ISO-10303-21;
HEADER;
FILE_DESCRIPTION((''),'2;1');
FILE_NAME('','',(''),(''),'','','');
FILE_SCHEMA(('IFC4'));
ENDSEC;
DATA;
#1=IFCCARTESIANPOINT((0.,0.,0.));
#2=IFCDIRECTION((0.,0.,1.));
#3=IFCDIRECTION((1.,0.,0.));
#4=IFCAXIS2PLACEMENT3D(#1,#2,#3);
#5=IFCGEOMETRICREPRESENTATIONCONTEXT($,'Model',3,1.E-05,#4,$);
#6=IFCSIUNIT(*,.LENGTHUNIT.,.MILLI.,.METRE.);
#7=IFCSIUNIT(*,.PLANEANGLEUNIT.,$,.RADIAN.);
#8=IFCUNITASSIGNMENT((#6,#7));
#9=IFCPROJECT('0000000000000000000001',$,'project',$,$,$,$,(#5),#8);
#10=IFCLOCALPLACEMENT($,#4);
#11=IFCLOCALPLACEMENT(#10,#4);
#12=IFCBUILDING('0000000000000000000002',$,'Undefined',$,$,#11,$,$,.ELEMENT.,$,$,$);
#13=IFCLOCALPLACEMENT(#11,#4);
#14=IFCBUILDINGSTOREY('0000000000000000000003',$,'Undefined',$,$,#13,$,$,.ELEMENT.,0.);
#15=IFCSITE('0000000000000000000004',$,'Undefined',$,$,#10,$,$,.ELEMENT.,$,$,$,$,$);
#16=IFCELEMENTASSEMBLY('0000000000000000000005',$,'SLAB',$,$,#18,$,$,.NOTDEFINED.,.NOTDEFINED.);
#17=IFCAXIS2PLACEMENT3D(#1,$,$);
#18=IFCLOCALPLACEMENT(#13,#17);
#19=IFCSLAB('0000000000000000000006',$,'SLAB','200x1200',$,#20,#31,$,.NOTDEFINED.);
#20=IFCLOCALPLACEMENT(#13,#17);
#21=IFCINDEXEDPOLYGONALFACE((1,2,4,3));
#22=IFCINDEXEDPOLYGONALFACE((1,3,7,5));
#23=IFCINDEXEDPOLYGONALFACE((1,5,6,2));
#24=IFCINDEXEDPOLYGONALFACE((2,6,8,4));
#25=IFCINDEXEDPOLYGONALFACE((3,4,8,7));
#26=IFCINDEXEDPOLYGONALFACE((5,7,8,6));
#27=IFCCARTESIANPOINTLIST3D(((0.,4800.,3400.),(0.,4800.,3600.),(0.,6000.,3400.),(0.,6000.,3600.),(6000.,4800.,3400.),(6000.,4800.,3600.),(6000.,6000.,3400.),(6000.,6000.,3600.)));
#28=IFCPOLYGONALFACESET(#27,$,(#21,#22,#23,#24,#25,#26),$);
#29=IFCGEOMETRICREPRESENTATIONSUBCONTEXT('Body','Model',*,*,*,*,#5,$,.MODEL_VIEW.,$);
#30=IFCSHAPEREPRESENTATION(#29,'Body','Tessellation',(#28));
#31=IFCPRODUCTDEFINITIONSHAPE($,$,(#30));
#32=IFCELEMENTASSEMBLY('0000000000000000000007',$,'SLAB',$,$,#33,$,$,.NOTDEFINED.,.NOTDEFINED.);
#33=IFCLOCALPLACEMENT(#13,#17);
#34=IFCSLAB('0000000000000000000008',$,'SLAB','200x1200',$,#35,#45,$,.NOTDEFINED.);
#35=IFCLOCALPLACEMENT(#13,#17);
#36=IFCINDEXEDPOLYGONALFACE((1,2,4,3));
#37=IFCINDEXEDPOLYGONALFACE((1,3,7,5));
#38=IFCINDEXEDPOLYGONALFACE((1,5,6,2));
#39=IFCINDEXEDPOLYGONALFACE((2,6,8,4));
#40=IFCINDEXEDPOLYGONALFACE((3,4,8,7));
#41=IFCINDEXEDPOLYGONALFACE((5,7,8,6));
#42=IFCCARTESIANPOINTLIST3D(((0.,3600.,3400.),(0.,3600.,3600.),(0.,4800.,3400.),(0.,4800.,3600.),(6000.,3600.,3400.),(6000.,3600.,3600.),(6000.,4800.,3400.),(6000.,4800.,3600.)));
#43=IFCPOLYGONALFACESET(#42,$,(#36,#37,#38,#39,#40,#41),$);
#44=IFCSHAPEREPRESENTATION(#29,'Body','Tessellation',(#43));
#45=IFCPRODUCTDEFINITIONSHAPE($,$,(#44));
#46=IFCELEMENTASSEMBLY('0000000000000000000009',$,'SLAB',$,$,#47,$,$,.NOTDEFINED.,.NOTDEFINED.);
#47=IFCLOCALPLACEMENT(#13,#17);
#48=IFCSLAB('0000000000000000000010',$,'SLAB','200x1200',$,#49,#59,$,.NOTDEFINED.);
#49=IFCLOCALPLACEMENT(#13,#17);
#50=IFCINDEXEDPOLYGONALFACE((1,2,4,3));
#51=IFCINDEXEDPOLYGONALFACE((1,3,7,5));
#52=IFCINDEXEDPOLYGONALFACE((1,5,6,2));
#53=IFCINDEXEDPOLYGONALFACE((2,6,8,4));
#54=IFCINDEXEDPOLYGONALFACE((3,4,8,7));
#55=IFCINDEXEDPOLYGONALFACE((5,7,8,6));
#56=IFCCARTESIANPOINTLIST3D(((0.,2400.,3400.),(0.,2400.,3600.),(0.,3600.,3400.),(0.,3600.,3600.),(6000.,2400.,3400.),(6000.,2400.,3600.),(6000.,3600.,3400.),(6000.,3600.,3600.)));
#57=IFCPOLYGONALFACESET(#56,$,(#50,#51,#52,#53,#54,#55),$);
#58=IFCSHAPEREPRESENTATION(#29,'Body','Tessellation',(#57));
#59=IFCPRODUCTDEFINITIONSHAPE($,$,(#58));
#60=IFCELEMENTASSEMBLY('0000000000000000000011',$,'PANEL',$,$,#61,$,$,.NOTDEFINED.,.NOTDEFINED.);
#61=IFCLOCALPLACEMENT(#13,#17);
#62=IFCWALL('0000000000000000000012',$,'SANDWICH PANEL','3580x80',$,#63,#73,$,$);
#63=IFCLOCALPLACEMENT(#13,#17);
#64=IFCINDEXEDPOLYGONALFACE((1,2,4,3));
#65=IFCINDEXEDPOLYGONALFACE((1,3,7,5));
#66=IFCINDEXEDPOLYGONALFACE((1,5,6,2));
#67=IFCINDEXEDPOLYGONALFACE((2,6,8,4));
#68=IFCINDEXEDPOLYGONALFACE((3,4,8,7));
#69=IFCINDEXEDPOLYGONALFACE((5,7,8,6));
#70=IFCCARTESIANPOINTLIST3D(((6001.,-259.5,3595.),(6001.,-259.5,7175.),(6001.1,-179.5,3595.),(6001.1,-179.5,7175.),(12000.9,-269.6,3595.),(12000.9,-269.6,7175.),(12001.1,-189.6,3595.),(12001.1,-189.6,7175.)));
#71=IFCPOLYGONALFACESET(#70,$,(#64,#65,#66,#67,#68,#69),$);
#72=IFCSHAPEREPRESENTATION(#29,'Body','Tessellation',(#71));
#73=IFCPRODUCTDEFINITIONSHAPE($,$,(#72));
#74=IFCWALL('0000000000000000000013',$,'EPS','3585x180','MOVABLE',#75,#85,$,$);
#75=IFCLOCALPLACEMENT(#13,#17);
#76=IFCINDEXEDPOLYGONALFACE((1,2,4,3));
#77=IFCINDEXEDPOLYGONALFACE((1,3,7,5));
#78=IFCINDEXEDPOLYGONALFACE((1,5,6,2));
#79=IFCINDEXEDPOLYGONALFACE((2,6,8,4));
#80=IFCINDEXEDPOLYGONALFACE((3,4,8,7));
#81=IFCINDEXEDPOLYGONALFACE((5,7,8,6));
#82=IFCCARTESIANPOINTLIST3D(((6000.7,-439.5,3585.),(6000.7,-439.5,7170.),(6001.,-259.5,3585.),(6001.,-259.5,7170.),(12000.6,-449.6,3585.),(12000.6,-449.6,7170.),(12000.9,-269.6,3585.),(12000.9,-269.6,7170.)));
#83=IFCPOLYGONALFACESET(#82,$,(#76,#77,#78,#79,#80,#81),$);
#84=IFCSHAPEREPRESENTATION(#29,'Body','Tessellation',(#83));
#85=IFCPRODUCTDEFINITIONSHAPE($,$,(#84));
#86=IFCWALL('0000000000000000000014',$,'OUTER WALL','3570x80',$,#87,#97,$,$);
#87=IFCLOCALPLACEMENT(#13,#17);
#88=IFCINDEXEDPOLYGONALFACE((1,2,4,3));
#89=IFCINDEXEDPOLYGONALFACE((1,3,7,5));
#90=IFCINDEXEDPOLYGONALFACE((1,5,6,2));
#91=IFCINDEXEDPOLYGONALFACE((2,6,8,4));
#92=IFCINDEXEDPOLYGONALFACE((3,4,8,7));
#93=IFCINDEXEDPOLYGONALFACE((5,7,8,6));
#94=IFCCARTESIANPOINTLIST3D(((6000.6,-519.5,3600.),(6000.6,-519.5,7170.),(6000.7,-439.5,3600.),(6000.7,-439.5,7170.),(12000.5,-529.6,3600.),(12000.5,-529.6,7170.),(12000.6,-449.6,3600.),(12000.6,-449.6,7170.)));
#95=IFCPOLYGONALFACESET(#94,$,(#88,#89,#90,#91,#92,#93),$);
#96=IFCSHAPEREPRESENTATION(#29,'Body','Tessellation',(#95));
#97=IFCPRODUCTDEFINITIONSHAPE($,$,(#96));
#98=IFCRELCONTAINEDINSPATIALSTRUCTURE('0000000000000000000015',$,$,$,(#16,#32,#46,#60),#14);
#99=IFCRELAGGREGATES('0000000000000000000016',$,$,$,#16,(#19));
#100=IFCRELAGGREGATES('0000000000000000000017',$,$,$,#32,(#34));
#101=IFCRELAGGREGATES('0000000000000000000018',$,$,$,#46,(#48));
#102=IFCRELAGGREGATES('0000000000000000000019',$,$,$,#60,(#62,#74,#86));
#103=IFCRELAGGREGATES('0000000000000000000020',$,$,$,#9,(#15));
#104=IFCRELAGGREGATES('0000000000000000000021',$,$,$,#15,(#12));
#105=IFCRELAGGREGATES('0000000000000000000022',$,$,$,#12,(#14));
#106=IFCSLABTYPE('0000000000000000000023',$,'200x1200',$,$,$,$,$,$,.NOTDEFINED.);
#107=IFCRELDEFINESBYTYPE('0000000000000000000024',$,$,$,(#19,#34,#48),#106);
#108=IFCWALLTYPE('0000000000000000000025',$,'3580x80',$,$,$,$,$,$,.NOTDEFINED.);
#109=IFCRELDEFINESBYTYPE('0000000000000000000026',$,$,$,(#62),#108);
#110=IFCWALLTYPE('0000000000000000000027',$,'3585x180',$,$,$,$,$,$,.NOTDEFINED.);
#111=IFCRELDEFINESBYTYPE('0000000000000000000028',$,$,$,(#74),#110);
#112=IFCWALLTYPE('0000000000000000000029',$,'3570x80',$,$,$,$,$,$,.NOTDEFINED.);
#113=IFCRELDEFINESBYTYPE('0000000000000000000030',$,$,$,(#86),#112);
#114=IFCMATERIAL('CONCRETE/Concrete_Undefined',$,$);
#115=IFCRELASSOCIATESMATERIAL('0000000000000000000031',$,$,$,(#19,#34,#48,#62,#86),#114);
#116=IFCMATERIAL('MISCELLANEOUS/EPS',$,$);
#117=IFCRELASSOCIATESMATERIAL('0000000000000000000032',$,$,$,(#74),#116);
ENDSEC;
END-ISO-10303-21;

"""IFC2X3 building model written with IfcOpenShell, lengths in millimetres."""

from ifc_helpers import new_model, si_unit, frame, frame_2d, origin_with_axes, place, context, subcontext, project, spatial, polyline, rectangle, outline, extrude, material, type_object, element, aggregate, save


model = new_model("IFC2X3")

# Units and contexts
model_context = context("Model", 3, precision=1e-05, world=origin_with_axes())
body_context = subcontext(model_context, "Body", "Model", "MODEL_VIEW")
ifc_project = project(units=[si_unit("LENGTHUNIT", "METRE", prefix="MILLI"), si_unit("PLANEANGLEUNIT", "RADIAN")], contexts=[model_context])

# Site, building, storey
site_placement = place(None, origin_with_axes())
site = spatial("IfcSite", under=ifc_project, at=site_placement, Name="Undefined", CompositionType="ELEMENT")
building_placement = place(site_placement, origin_with_axes())
building = spatial("IfcBuilding", under=site, at=building_placement, Name="Undefined", CompositionType="ELEMENT")
storey_placement = place(building_placement, origin_with_axes())
storey = spatial("IfcBuildingStorey", under=building, at=storey_placement, Name="Undefined", CompositionType="ELEMENT", Elevation=0.0)

# Element assemblies, slabs
ifc_material_1 = material(Name="CONCRETE/Concrete_Undefined")
slab_type = type_object("IfcSlabType", Name="200x1200", PredefinedType="NOTDEFINED")
assembly_1_placement = place(storey_placement, origin_with_axes())
assembly_1 = element("IfcElementAssembly", 1, at=assembly_1_placement, inside=storey, Name="SLAB", AssemblyPlace="NOTDEFINED", PredefinedType="NOTDEFINED")
slab_1_placement = place(assembly_1_placement, frame((6000.0, 4800.0, 3500.0), z_axis=(0.0, 0.0, 1.0), x_axis=(0.0, 1.0, 0.0)))
slab_1 = element("IfcSlab", 2, at=slab_1_placement, type_object=slab_type, material=ifc_material_1, Name="SLAB", Description="200x1200", PredefinedType="NOTDEFINED", context=body_context, shape_type="SweptSolid", body=[
    extrude(outline(polyline([(0.0, 0.0), (1200.0, 0.0), (1200.0, 6000.0), (0.0, 6000.0), (0.0, 0.0)])), frame((0.0, 0.0, -100.0), z_axis=(0.0, 0.0, 1.0), x_axis=(1.0, 0.0, 0.0)), (0.0, 0.0, 1.0), 200.0),
])
aggregate(assembly_1, [slab_1])
assembly_2_placement = place(storey_placement, origin_with_axes())
assembly_2 = element("IfcElementAssembly", 3, at=assembly_2_placement, inside=storey, Name="SLAB", AssemblyPlace="NOTDEFINED", PredefinedType="NOTDEFINED")
slab_2_placement = place(assembly_2_placement, frame((6000.0, 3600.0, 3500.0), z_axis=(0.0, 0.0, 1.0), x_axis=(0.0, 1.0, 0.0)))
slab_2 = element("IfcSlab", 4, at=slab_2_placement, type_object=slab_type, material=ifc_material_1, Name="SLAB", Description="200x1200", PredefinedType="NOTDEFINED", context=body_context, shape_type="SweptSolid", body=[
    extrude(outline(polyline([(0.0, 0.0), (1200.0, 0.0), (1200.0, 6000.0), (0.0, 6000.0), (0.0, 0.0)])), frame((0.0, 0.0, -100.0), z_axis=(0.0, 0.0, 1.0), x_axis=(1.0, 0.0, 0.0)), (0.0, 0.0, 1.0), 200.0),
])
aggregate(assembly_2, [slab_2])
assembly_3_placement = place(storey_placement, origin_with_axes())
assembly_3 = element("IfcElementAssembly", 5, at=assembly_3_placement, inside=storey, Name="SLAB", AssemblyPlace="NOTDEFINED", PredefinedType="NOTDEFINED")
slab_3_placement = place(assembly_3_placement, frame((6000.0, 2400.0, 3500.0), z_axis=(0.0, 0.0, 1.0), x_axis=(0.0, 1.0, 0.0)))
slab_3 = element("IfcSlab", 6, at=slab_3_placement, type_object=slab_type, material=ifc_material_1, Name="SLAB", Description="200x1200", PredefinedType="NOTDEFINED", context=body_context, shape_type="SweptSolid", body=[
    extrude(outline(polyline([(0.0, 0.0), (1200.0, 0.0), (1200.0, 6000.0), (0.0, 6000.0), (0.0, 0.0)])), frame((0.0, 0.0, -100.0), z_axis=(0.0, 0.0, 1.0), x_axis=(1.0, 0.0, 0.0)), (0.0, 0.0, 1.0), 200.0),
])
aggregate(assembly_3, [slab_3])

# Element assembly, walls
assembly_4_placement = place(storey_placement, origin_with_axes())
assembly_4 = element("IfcElementAssembly", 7, at=assembly_4_placement, inside=storey, Name="PANEL", AssemblyPlace="NOTDEFINED", PredefinedType="NOTDEFINED")
wall_type_1 = type_object("IfcWallType", Name="3580x80", PredefinedType="NOTDEFINED")
wall_1_placement = place(assembly_4_placement, frame((6001.1, -219.5, 3595.0), z_axis=(0.0, 0.0, 1.0), x_axis=(0.999999, -0.001684, 0.0)))
wall_1 = element("IfcWall", 8, at=wall_1_placement, type_object=wall_type_1, material=ifc_material_1, Name="SANDWICH PANEL", Description="3580x80", context=body_context, shape_type="SweptSolid", body=[
    extrude(rectangle(XDim=6000.0, YDim=80.0, at=frame_2d((0.0, 3000.0), x_axis=(0.0, -1.0))), frame((0.0, 0.0, 0.0), z_axis=(0.0, 0.0, 1.0), x_axis=(0.0, -1.0, 0.0)), (0.0, 0.0, 1.0), 3580.0),
])
ifc_material_2 = material(Name="MISCELLANEOUS/EPS")
wall_type_2 = type_object("IfcWallType", Name="3585x180", PredefinedType="NOTDEFINED")
wall_2_placement = place(assembly_4_placement, frame((6000.8, -349.5, 3585.0), z_axis=(0.0, 0.0, 1.0), x_axis=(0.999999, -0.001684, 0.0)))
wall_2 = element("IfcWall", 9, at=wall_2_placement, type_object=wall_type_2, material=ifc_material_2, Name="EPS", Description="3585x180", ObjectType="MOVABLE", context=body_context, shape_type="SweptSolid", body=[
    extrude(rectangle(XDim=6000.0, YDim=180.0, at=frame_2d((0.0, 3000.0), x_axis=(0.0, -1.0))), frame((0.0, 0.0, 0.0), z_axis=(0.0, 0.0, 1.0), x_axis=(0.0, -1.0, 0.0)), (0.0, 0.0, 1.0), 3585.0),
])
wall_type_3 = type_object("IfcWallType", Name="3570x80", PredefinedType="NOTDEFINED")
wall_3_placement = place(assembly_4_placement, frame((6000.6, -479.5, 3600.0), z_axis=(0.0, 0.0, 1.0), x_axis=(0.999999, -0.001684, 0.0)))
wall_3 = element("IfcWall", 10, at=wall_3_placement, type_object=wall_type_3, material=ifc_material_1, Name="OUTER WALL", Description="3570x80", context=body_context, shape_type="SweptSolid", body=[
    extrude(rectangle(XDim=6000.0, YDim=80.0, at=frame_2d((0.0, 3000.0), x_axis=(0.0, -1.0))), frame((0.0, 0.0, 0.0), z_axis=(0.0, 0.0, 1.0), x_axis=(0.0, -1.0, 0.0)), (0.0, 0.0, 1.0), 3570.0),
])
aggregate(assembly_4, [wall_1, wall_2, wall_3])

save(model, "model.ifc")
